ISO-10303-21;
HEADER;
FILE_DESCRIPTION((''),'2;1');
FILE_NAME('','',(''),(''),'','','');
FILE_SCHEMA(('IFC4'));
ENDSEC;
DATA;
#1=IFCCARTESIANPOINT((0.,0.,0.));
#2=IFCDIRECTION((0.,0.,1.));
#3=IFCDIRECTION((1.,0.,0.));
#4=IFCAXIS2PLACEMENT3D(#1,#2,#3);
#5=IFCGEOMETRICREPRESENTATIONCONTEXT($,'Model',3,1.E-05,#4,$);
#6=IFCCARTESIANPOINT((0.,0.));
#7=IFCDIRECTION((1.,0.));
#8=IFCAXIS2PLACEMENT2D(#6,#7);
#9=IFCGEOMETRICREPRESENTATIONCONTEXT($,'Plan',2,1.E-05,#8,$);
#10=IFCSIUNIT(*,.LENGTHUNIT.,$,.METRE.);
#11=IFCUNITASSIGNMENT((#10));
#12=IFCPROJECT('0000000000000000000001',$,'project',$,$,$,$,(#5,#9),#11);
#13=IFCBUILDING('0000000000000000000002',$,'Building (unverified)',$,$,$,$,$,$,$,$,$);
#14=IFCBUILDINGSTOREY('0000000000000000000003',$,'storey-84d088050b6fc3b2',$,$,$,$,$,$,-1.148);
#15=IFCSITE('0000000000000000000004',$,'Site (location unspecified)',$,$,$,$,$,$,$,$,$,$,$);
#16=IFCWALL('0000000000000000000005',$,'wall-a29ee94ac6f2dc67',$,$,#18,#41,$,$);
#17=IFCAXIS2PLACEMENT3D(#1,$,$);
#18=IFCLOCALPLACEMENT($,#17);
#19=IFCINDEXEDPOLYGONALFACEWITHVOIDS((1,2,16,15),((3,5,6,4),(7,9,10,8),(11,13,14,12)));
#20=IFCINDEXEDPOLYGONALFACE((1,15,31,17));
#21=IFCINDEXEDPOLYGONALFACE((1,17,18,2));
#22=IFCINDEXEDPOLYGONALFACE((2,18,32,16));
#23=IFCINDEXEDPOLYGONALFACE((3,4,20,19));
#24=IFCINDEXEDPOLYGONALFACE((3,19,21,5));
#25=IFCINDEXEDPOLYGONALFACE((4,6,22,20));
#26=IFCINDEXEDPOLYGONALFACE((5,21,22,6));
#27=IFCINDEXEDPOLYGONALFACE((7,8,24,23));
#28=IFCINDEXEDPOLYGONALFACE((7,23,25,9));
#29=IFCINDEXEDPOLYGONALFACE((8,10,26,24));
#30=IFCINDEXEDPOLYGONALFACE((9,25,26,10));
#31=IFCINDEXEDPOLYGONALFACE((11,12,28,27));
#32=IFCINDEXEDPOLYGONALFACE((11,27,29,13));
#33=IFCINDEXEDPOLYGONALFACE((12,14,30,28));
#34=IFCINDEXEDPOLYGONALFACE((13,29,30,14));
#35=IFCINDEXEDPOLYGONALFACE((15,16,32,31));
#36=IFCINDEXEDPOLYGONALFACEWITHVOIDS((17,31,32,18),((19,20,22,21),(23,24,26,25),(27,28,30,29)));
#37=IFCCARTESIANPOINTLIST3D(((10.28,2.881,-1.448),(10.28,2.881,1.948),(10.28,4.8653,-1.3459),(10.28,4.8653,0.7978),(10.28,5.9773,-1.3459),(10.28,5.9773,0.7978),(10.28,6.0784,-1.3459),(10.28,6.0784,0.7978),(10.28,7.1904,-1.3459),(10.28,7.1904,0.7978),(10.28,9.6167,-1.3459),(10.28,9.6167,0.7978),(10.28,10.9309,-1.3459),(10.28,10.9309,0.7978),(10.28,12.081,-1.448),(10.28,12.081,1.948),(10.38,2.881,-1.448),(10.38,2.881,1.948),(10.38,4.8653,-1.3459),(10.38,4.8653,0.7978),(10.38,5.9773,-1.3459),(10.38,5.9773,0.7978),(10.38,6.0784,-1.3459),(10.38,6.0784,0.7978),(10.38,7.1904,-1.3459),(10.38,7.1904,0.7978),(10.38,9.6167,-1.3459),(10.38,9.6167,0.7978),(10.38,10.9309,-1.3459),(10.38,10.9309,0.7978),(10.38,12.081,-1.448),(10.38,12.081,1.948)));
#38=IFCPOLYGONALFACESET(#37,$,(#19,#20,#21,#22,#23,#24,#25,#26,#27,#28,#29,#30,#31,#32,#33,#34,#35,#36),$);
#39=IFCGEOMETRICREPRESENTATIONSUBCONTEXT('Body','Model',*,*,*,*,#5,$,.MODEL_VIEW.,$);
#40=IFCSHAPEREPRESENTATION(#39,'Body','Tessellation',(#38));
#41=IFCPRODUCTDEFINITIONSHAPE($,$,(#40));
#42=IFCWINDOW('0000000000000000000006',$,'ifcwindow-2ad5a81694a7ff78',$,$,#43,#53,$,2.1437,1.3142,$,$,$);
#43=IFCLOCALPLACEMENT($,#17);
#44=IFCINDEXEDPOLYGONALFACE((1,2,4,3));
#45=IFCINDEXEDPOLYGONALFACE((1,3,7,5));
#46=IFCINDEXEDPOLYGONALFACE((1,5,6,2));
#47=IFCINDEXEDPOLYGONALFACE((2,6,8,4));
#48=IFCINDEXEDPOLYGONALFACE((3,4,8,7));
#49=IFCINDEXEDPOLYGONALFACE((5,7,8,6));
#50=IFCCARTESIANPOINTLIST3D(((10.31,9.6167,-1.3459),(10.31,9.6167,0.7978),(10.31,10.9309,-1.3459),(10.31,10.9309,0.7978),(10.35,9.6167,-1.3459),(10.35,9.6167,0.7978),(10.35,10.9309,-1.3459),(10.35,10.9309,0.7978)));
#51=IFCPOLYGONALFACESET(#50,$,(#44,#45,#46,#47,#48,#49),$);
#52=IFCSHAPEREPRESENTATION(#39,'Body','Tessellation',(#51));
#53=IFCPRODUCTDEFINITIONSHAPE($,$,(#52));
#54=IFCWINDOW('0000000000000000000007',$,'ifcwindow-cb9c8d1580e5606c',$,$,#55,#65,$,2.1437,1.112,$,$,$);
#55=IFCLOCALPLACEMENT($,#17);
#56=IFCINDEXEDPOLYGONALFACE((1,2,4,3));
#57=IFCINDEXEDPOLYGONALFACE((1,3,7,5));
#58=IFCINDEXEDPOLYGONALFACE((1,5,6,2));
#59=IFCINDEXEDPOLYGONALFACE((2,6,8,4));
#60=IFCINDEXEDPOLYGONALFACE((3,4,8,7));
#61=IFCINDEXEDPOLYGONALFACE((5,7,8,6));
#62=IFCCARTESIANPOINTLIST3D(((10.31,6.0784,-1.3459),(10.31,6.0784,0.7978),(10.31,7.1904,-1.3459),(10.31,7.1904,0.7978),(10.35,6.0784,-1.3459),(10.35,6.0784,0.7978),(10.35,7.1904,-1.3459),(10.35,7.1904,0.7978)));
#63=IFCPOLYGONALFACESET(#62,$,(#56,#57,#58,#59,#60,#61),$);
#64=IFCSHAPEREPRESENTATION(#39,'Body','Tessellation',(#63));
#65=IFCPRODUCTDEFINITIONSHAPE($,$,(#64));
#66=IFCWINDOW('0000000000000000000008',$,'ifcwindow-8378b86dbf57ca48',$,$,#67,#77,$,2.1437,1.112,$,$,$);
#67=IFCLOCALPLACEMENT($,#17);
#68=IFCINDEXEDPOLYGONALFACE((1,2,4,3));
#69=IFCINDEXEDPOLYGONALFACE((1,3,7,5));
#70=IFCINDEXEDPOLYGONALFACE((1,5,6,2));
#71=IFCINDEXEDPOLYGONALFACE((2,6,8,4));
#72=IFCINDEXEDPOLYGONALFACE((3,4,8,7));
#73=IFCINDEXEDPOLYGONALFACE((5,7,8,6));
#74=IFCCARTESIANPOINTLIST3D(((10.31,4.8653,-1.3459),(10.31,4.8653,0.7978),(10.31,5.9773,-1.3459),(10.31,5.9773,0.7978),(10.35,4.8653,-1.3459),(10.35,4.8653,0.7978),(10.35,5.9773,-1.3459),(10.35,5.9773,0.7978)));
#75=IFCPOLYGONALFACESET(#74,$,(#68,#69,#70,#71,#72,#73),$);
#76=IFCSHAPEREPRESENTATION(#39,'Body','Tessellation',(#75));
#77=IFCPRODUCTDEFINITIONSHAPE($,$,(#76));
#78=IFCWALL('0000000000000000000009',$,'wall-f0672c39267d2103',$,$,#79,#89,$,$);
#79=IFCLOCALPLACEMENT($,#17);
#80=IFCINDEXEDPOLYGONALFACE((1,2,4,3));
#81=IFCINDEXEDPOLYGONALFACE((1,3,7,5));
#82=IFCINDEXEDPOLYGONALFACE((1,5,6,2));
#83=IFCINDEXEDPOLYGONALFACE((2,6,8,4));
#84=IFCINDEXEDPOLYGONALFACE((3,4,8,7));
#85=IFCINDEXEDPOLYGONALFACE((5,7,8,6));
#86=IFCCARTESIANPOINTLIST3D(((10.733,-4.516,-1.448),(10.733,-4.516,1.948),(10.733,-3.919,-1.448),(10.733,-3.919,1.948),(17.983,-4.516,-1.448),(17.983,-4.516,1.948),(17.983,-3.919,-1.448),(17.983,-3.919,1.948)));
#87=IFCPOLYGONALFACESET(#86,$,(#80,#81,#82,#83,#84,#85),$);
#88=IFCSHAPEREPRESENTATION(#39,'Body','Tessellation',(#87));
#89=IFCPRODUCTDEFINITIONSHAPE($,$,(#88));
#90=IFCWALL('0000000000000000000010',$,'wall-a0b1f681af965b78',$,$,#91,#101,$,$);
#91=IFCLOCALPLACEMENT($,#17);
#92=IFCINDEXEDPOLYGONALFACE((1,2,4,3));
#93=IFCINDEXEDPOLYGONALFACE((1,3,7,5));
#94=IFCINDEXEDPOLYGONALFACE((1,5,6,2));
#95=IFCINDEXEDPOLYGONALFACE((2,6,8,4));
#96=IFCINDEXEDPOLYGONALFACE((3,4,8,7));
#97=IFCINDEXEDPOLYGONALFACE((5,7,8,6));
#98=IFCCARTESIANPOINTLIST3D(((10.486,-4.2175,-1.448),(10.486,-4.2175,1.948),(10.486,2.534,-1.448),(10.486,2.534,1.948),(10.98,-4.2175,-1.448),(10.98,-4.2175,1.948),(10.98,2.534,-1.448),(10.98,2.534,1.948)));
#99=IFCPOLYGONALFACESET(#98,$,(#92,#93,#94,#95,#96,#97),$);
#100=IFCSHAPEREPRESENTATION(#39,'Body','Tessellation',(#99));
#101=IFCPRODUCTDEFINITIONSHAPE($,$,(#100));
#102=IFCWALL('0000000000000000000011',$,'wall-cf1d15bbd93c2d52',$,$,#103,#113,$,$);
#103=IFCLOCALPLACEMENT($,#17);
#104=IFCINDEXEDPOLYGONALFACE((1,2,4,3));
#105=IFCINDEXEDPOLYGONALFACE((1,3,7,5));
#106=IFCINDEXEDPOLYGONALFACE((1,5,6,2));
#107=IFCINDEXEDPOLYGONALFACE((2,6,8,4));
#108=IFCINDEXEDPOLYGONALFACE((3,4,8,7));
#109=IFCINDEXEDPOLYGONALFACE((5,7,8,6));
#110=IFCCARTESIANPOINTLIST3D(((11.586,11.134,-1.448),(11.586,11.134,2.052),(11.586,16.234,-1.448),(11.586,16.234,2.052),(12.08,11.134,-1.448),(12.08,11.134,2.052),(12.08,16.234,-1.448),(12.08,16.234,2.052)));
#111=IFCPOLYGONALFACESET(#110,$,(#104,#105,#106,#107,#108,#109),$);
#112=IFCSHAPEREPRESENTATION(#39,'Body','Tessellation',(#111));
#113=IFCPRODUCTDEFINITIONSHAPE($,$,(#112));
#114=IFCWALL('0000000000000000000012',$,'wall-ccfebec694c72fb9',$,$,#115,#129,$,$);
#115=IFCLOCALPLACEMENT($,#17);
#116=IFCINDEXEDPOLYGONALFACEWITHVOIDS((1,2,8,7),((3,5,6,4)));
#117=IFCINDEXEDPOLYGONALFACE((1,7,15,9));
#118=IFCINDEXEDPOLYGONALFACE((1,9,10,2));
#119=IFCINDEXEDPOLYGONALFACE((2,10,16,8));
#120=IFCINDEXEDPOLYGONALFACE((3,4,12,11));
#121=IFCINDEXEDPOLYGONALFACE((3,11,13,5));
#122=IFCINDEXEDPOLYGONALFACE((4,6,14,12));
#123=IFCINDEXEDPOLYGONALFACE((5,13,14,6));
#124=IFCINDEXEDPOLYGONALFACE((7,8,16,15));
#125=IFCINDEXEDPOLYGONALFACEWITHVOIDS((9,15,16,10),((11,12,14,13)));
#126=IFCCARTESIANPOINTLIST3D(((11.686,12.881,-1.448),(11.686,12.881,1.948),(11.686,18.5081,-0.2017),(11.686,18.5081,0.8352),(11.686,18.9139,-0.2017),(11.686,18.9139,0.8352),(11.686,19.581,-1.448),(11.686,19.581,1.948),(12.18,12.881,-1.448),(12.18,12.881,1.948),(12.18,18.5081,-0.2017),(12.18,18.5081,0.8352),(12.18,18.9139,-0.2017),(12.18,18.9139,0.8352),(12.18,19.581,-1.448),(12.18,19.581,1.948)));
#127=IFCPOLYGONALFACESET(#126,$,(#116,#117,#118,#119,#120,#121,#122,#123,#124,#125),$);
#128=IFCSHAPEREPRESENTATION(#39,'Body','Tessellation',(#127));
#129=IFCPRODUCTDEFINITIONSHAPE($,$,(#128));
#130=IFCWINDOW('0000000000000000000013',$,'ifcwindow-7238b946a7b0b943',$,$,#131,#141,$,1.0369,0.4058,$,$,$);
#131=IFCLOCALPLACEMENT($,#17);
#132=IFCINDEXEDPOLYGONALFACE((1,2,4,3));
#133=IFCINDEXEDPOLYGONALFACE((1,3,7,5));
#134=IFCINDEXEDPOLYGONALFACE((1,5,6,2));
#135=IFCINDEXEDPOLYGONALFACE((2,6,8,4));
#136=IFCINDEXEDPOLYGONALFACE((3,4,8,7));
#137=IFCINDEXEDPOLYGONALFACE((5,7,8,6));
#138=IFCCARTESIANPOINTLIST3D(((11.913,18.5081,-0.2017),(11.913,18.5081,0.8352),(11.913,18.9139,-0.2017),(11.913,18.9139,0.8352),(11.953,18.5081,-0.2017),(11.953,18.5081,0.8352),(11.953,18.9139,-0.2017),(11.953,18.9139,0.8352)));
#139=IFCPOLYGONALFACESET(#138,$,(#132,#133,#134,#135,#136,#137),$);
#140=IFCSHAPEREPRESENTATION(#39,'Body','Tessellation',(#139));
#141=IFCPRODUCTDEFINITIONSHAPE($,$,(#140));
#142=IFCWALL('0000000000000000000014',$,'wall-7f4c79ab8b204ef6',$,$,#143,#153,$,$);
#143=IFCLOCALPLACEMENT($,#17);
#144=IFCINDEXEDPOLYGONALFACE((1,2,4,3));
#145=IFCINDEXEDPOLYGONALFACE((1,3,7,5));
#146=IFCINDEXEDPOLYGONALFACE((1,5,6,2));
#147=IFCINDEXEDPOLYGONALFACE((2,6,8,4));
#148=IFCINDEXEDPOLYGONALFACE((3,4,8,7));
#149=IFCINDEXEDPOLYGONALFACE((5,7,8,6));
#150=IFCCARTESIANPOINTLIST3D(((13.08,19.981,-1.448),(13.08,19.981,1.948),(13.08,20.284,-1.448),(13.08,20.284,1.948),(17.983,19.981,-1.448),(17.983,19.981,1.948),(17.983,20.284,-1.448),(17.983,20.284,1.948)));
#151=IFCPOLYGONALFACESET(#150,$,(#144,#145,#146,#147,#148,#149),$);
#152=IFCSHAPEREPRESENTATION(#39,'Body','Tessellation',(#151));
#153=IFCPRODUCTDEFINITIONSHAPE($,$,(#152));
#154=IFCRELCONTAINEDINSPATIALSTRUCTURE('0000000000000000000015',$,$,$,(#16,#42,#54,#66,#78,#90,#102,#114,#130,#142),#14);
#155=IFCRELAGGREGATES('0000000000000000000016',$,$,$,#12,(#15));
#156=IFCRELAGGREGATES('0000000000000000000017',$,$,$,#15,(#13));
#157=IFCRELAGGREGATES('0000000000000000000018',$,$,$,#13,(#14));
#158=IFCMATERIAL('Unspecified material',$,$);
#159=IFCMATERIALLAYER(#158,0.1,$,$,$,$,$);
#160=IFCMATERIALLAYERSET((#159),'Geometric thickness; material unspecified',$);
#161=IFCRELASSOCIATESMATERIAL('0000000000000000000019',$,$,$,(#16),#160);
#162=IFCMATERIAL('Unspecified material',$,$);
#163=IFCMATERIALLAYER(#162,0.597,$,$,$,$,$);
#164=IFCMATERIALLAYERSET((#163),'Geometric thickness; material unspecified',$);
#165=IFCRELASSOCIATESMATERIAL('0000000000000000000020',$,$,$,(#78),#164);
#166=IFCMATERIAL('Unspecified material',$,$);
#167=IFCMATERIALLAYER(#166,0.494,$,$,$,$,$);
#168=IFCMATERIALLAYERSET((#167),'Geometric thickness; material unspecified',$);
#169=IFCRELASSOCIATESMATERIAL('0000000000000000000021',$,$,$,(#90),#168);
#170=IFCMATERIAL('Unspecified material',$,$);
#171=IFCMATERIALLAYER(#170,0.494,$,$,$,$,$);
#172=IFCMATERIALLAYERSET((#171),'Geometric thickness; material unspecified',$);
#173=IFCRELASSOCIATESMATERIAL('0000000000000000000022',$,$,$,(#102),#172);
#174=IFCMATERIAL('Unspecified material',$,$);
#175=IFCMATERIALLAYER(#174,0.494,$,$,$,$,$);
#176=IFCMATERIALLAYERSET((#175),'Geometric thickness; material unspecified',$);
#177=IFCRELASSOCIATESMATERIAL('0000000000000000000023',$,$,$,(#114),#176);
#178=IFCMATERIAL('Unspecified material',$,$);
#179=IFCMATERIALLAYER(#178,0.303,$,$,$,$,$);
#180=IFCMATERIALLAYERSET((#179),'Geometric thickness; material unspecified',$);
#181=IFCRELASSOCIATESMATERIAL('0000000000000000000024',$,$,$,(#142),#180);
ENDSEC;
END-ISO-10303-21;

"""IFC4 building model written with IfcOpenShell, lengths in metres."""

from ifc_helpers import new_model, si_unit, frame, origin_with_axes, origin_2d_with_axis, place, context, subcontext, project, spatial, indexed_curve, outline, extrude, material, layer, layer_set, layer_usage, element, fill, save


model = new_model("IFC4")

# Units and contexts
model_context = context("Model", 3, precision=1e-05, world=origin_with_axes())
plan_context = context("Plan", 2, precision=1e-05, world=origin_2d_with_axis())
body_context = subcontext(model_context, "Body", "Model", "MODEL_VIEW")
ifc_project = project(units=[si_unit("LENGTHUNIT", "METRE")], contexts=[model_context, plan_context])

# Site, building, storey
site = spatial("IfcSite", under=ifc_project, Name="Site (location unspecified)")
building = spatial("IfcBuilding", under=site, Name="Building (unverified)")
storey = spatial("IfcBuildingStorey", under=building, Name="storey-84d088050b6fc3b2", Elevation=-1.148)

# Wall, openings, windows
ifc_material_1 = material(Name="Unspecified material")
ifc_layer_1 = layer(ifc_material_1, 0.1)
ifc_layer_set_1 = layer_set([ifc_layer_1], Name="Geometric thickness; material unspecified")
ifc_layer_usage_1 = layer_usage(ifc_layer_set_1, "AXIS2", "POSITIVE", -0.05)
wall_1_placement = place(None, frame((10.33, 12.081, -1.448), z_axis=(0.0, 0.0, 1.0), x_axis=(0.0, -1.0, 0.0)))
wall_1 = element("IfcWall", 1, at=wall_1_placement, inside=storey, material=ifc_layer_usage_1, Name="wall-a29ee94ac6f2dc67", context=body_context, shape_type="SweptSolid", body=[
    extrude(outline(indexed_curve([(0.0, 0.0), (0.0, 0.1), (9.2, 0.1), (9.2, 0.0), (0.0, 0.0)], self_intersect=False)), frame((0.0, -0.05, 0.0), z_axis=(0.0, 0.0, 1.0), x_axis=(1.0, 0.0, 0.0)), (0.0, 0.0, 1.0), 3.396),
])
opening_1_placement = place(wall_1_placement, frame((1.1501, -0.06, 0.1021), z_axis=(0.0, 0.0, 1.0), x_axis=(1.0, 0.0, 0.0)))
opening_1 = element("IfcOpeningElement", 2, at=opening_1_placement, cuts=wall_1, context=body_context, shape_type="SweptSolid", body=[
    extrude(outline(indexed_curve([(0.0, 0.0), (0.0, 0.12), (1.3142, 0.12), (1.3142, 0.0), (0.0, 0.0)], self_intersect=False)), origin_with_axes(), (0.0, 0.0, 1.0), 2.1437),
])
opening_2_placement = place(wall_1_placement, frame((4.8906, -0.06, 0.1021), z_axis=(0.0, 0.0, 1.0), x_axis=(1.0, 0.0, 0.0)))
opening_2 = element("IfcOpeningElement", 3, at=opening_2_placement, cuts=wall_1, context=body_context, shape_type="SweptSolid", body=[
    extrude(outline(indexed_curve([(0.0, 0.0), (0.0, 0.12), (1.112, 0.12), (1.112, 0.0), (0.0, 0.0)], self_intersect=False)), origin_with_axes(), (0.0, 0.0, 1.0), 2.1437),
])
opening_3_placement = place(wall_1_placement, frame((6.1037, -0.06, 0.1021), z_axis=(0.0, 0.0, 1.0), x_axis=(1.0, 0.0, 0.0)))
opening_3 = element("IfcOpeningElement", 4, at=opening_3_placement, cuts=wall_1, context=body_context, shape_type="SweptSolid", body=[
    extrude(outline(indexed_curve([(0.0, 0.0), (0.0, 0.12), (1.112, 0.12), (1.112, 0.0), (0.0, 0.0)], self_intersect=False)), origin_with_axes(), (0.0, 0.0, 1.0), 2.1437),
])
window_1_placement = place(None, frame((10.31, 10.9309, -1.3459), z_axis=(0.0, 0.0, 1.0), x_axis=(0.0, -1.0, 0.0)))
window_1 = element("IfcWindow", 5, at=window_1_placement, inside=storey, Name="ifcwindow-2ad5a81694a7ff78", OverallHeight=2.1437, OverallWidth=1.3142, context=body_context, shape_type="SweptSolid", body=[
    extrude(outline(indexed_curve([(0.0, 0.0), (0.0, 0.04), (1.3142, 0.04), (1.3142, 0.0), (0.0, 0.0)], self_intersect=False)), origin_with_axes(), (0.0, 0.0, 1.0), 2.1437),
])
fill(opening_1, window_1)
window_2_placement = place(None, frame((10.31, 7.1904, -1.3459), z_axis=(0.0, 0.0, 1.0), x_axis=(0.0, -1.0, 0.0)))
window_2 = element("IfcWindow", 6, at=window_2_placement, inside=storey, Name="ifcwindow-cb9c8d1580e5606c", OverallHeight=2.1437, OverallWidth=1.112, context=body_context, shape_type="SweptSolid", body=[
    extrude(outline(indexed_curve([(0.0, 0.0), (0.0, 0.04), (1.112, 0.04), (1.112, 0.0), (0.0, 0.0)], self_intersect=False)), origin_with_axes(), (0.0, 0.0, 1.0), 2.1437),
])
fill(opening_2, window_2)
window_3_placement = place(None, frame((10.31, 5.9773, -1.3459), z_axis=(0.0, 0.0, 1.0), x_axis=(0.0, -1.0, 0.0)))
window_3 = element("IfcWindow", 7, at=window_3_placement, inside=storey, Name="ifcwindow-8378b86dbf57ca48", OverallHeight=2.1437, OverallWidth=1.112, context=body_context, shape_type="SweptSolid", body=[
    extrude(outline(indexed_curve([(0.0, 0.0), (0.0, 0.04), (1.112, 0.04), (1.112, 0.0), (0.0, 0.0)], self_intersect=False)), origin_with_axes(), (0.0, 0.0, 1.0), 2.1437),
])
fill(opening_3, window_3)

# Walls
ifc_material_2 = material(Name="Unspecified material")
ifc_layer_2 = layer(ifc_material_2, 0.597)
ifc_layer_set_2 = layer_set([ifc_layer_2], Name="Geometric thickness; material unspecified")
ifc_layer_usage_2 = layer_usage(ifc_layer_set_2, "AXIS2", "POSITIVE", -0.2985)
wall_2_placement = place(None, frame((17.983, -4.2175, -1.448), z_axis=(0.0, 0.0, 1.0), x_axis=(-1.0, 0.0, 0.0)))
element("IfcWall", 8, at=wall_2_placement, inside=storey, material=ifc_layer_usage_2, Name="wall-f0672c39267d2103", context=body_context, shape_type="SweptSolid", body=[
    extrude(outline(indexed_curve([(0.0, 0.0), (0.0, 0.597), (7.25, 0.597), (7.25, 0.0), (0.0, 0.0)], self_intersect=False)), frame((0.0, -0.2985, 0.0), z_axis=(0.0, 0.0, 1.0), x_axis=(1.0, 0.0, 0.0)), (0.0, 0.0, 1.0), 3.396),
])
ifc_material_3 = material(Name="Unspecified material")
ifc_layer_3 = layer(ifc_material_3, 0.494)
ifc_layer_set_3 = layer_set([ifc_layer_3], Name="Geometric thickness; material unspecified")
ifc_layer_usage_3 = layer_usage(ifc_layer_set_3, "AXIS2", "POSITIVE", -0.247)
wall_3_placement = place(None, frame((10.733, -4.2175, -1.448), z_axis=(0.0, 0.0, 1.0), x_axis=(0.0, 1.0, 0.0)))
element("IfcWall", 9, at=wall_3_placement, inside=storey, material=ifc_layer_usage_3, Name="wall-a0b1f681af965b78", context=body_context, shape_type="SweptSolid", body=[
    extrude(outline(indexed_curve([(0.0, 0.0), (0.0, 0.494), (6.7515, 0.494), (6.7515, 0.0), (0.0, 0.0)], self_intersect=False)), frame((0.0, -0.247, 0.0), z_axis=(0.0, 0.0, 1.0), x_axis=(1.0, 0.0, 0.0)), (0.0, 0.0, 1.0), 3.396),
])
ifc_material_4 = material(Name="Unspecified material")
ifc_layer_4 = layer(ifc_material_4, 0.494)
ifc_layer_set_4 = layer_set([ifc_layer_4], Name="Geometric thickness; material unspecified")
ifc_layer_usage_4 = layer_usage(ifc_layer_set_4, "AXIS2", "POSITIVE", -0.247)
wall_4_placement = place(None, frame((11.833, 11.134, -1.448), z_axis=(0.0, 0.0, 1.0), x_axis=(0.0, 1.0, 0.0)))
element("IfcWall", 10, at=wall_4_placement, inside=storey, material=ifc_layer_usage_4, Name="wall-cf1d15bbd93c2d52", context=body_context, shape_type="SweptSolid", body=[
    extrude(outline(indexed_curve([(0.0, 0.0), (0.0, 0.494), (5.1, 0.494), (5.1, 0.0), (0.0, 0.0)], self_intersect=False)), frame((0.0, -0.247, 0.0), z_axis=(0.0, 0.0, 1.0), x_axis=(1.0, 0.0, 0.0)), (0.0, 0.0, 1.0), 3.5),
])

# Wall, opening, window
ifc_material_5 = material(Name="Unspecified material")
ifc_layer_5 = layer(ifc_material_5, 0.494)
ifc_layer_set_5 = layer_set([ifc_layer_5], Name="Geometric thickness; material unspecified")
ifc_layer_usage_5 = layer_usage(ifc_layer_set_5, "AXIS2", "POSITIVE", -0.247)
wall_5_placement = place(None, frame((11.933, 12.881, -1.448), z_axis=(0.0, 0.0, 1.0), x_axis=(0.0, 1.0, 0.0)))
wall_5 = element("IfcWall", 11, at=wall_5_placement, inside=storey, material=ifc_layer_usage_5, Name="wall-ccfebec694c72fb9", context=body_context, shape_type="SweptSolid", body=[
    extrude(outline(indexed_curve([(0.0, 0.0), (0.0, 0.494), (6.7, 0.494), (6.7, 0.0), (0.0, 0.0)], self_intersect=False)), frame((0.0, -0.247, 0.0), z_axis=(0.0, 0.0, 1.0), x_axis=(1.0, 0.0, 0.0)), (0.0, 0.0, 1.0), 3.396),
])
opening_4_placement = place(wall_5_placement, frame((5.6271, -0.257, 1.2463), z_axis=(0.0, 0.0, 1.0), x_axis=(1.0, 0.0, 0.0)))
opening_4 = element("IfcOpeningElement", 12, at=opening_4_placement, cuts=wall_5, context=body_context, shape_type="SweptSolid", body=[
    extrude(outline(indexed_curve([(0.0, 0.0), (0.0, 0.514), (0.4058, 0.514), (0.4058, 0.0), (0.0, 0.0)], self_intersect=False)), origin_with_axes(), (0.0, 0.0, 1.0), 1.0369),
])
window_4_placement = place(None, frame((11.953, 18.5081, -0.2017), z_axis=(0.0, 0.0, 1.0), x_axis=(0.0, 1.0, 0.0)))
window_4 = element("IfcWindow", 13, at=window_4_placement, inside=storey, Name="ifcwindow-7238b946a7b0b943", OverallHeight=1.0369, OverallWidth=0.4058, context=body_context, shape_type="SweptSolid", body=[
    extrude(outline(indexed_curve([(0.0, 0.0), (0.0, 0.04), (0.4058, 0.04), (0.4058, 0.0), (0.0, 0.0)], self_intersect=False)), origin_with_axes(), (0.0, 0.0, 1.0), 1.0369),
])
fill(opening_4, window_4)

# Wall
ifc_material_6 = material(Name="Unspecified material")
ifc_layer_6 = layer(ifc_material_6, 0.303)
ifc_layer_set_6 = layer_set([ifc_layer_6], Name="Geometric thickness; material unspecified")
ifc_layer_usage_6 = layer_usage(ifc_layer_set_6, "AXIS2", "POSITIVE", -0.1515)
wall_6_placement = place(None, frame((13.08, 20.1325, -1.448), z_axis=(0.0, 0.0, 1.0), x_axis=(1.0, 0.0, 0.0)))
element("IfcWall", 14, at=wall_6_placement, inside=storey, material=ifc_layer_usage_6, Name="wall-7f4c79ab8b204ef6", context=body_context, shape_type="SweptSolid", body=[
    extrude(outline(indexed_curve([(0.0, 0.0), (0.0, 0.303), (4.903, 0.303), (4.903, 0.0), (0.0, 0.0)], self_intersect=False)), frame((0.0, -0.1515, 0.0), z_axis=(0.0, 0.0, 1.0), x_axis=(1.0, 0.0, 0.0)), (0.0, 0.0, 1.0), 3.396),
])

save(model, "model.ifc")
